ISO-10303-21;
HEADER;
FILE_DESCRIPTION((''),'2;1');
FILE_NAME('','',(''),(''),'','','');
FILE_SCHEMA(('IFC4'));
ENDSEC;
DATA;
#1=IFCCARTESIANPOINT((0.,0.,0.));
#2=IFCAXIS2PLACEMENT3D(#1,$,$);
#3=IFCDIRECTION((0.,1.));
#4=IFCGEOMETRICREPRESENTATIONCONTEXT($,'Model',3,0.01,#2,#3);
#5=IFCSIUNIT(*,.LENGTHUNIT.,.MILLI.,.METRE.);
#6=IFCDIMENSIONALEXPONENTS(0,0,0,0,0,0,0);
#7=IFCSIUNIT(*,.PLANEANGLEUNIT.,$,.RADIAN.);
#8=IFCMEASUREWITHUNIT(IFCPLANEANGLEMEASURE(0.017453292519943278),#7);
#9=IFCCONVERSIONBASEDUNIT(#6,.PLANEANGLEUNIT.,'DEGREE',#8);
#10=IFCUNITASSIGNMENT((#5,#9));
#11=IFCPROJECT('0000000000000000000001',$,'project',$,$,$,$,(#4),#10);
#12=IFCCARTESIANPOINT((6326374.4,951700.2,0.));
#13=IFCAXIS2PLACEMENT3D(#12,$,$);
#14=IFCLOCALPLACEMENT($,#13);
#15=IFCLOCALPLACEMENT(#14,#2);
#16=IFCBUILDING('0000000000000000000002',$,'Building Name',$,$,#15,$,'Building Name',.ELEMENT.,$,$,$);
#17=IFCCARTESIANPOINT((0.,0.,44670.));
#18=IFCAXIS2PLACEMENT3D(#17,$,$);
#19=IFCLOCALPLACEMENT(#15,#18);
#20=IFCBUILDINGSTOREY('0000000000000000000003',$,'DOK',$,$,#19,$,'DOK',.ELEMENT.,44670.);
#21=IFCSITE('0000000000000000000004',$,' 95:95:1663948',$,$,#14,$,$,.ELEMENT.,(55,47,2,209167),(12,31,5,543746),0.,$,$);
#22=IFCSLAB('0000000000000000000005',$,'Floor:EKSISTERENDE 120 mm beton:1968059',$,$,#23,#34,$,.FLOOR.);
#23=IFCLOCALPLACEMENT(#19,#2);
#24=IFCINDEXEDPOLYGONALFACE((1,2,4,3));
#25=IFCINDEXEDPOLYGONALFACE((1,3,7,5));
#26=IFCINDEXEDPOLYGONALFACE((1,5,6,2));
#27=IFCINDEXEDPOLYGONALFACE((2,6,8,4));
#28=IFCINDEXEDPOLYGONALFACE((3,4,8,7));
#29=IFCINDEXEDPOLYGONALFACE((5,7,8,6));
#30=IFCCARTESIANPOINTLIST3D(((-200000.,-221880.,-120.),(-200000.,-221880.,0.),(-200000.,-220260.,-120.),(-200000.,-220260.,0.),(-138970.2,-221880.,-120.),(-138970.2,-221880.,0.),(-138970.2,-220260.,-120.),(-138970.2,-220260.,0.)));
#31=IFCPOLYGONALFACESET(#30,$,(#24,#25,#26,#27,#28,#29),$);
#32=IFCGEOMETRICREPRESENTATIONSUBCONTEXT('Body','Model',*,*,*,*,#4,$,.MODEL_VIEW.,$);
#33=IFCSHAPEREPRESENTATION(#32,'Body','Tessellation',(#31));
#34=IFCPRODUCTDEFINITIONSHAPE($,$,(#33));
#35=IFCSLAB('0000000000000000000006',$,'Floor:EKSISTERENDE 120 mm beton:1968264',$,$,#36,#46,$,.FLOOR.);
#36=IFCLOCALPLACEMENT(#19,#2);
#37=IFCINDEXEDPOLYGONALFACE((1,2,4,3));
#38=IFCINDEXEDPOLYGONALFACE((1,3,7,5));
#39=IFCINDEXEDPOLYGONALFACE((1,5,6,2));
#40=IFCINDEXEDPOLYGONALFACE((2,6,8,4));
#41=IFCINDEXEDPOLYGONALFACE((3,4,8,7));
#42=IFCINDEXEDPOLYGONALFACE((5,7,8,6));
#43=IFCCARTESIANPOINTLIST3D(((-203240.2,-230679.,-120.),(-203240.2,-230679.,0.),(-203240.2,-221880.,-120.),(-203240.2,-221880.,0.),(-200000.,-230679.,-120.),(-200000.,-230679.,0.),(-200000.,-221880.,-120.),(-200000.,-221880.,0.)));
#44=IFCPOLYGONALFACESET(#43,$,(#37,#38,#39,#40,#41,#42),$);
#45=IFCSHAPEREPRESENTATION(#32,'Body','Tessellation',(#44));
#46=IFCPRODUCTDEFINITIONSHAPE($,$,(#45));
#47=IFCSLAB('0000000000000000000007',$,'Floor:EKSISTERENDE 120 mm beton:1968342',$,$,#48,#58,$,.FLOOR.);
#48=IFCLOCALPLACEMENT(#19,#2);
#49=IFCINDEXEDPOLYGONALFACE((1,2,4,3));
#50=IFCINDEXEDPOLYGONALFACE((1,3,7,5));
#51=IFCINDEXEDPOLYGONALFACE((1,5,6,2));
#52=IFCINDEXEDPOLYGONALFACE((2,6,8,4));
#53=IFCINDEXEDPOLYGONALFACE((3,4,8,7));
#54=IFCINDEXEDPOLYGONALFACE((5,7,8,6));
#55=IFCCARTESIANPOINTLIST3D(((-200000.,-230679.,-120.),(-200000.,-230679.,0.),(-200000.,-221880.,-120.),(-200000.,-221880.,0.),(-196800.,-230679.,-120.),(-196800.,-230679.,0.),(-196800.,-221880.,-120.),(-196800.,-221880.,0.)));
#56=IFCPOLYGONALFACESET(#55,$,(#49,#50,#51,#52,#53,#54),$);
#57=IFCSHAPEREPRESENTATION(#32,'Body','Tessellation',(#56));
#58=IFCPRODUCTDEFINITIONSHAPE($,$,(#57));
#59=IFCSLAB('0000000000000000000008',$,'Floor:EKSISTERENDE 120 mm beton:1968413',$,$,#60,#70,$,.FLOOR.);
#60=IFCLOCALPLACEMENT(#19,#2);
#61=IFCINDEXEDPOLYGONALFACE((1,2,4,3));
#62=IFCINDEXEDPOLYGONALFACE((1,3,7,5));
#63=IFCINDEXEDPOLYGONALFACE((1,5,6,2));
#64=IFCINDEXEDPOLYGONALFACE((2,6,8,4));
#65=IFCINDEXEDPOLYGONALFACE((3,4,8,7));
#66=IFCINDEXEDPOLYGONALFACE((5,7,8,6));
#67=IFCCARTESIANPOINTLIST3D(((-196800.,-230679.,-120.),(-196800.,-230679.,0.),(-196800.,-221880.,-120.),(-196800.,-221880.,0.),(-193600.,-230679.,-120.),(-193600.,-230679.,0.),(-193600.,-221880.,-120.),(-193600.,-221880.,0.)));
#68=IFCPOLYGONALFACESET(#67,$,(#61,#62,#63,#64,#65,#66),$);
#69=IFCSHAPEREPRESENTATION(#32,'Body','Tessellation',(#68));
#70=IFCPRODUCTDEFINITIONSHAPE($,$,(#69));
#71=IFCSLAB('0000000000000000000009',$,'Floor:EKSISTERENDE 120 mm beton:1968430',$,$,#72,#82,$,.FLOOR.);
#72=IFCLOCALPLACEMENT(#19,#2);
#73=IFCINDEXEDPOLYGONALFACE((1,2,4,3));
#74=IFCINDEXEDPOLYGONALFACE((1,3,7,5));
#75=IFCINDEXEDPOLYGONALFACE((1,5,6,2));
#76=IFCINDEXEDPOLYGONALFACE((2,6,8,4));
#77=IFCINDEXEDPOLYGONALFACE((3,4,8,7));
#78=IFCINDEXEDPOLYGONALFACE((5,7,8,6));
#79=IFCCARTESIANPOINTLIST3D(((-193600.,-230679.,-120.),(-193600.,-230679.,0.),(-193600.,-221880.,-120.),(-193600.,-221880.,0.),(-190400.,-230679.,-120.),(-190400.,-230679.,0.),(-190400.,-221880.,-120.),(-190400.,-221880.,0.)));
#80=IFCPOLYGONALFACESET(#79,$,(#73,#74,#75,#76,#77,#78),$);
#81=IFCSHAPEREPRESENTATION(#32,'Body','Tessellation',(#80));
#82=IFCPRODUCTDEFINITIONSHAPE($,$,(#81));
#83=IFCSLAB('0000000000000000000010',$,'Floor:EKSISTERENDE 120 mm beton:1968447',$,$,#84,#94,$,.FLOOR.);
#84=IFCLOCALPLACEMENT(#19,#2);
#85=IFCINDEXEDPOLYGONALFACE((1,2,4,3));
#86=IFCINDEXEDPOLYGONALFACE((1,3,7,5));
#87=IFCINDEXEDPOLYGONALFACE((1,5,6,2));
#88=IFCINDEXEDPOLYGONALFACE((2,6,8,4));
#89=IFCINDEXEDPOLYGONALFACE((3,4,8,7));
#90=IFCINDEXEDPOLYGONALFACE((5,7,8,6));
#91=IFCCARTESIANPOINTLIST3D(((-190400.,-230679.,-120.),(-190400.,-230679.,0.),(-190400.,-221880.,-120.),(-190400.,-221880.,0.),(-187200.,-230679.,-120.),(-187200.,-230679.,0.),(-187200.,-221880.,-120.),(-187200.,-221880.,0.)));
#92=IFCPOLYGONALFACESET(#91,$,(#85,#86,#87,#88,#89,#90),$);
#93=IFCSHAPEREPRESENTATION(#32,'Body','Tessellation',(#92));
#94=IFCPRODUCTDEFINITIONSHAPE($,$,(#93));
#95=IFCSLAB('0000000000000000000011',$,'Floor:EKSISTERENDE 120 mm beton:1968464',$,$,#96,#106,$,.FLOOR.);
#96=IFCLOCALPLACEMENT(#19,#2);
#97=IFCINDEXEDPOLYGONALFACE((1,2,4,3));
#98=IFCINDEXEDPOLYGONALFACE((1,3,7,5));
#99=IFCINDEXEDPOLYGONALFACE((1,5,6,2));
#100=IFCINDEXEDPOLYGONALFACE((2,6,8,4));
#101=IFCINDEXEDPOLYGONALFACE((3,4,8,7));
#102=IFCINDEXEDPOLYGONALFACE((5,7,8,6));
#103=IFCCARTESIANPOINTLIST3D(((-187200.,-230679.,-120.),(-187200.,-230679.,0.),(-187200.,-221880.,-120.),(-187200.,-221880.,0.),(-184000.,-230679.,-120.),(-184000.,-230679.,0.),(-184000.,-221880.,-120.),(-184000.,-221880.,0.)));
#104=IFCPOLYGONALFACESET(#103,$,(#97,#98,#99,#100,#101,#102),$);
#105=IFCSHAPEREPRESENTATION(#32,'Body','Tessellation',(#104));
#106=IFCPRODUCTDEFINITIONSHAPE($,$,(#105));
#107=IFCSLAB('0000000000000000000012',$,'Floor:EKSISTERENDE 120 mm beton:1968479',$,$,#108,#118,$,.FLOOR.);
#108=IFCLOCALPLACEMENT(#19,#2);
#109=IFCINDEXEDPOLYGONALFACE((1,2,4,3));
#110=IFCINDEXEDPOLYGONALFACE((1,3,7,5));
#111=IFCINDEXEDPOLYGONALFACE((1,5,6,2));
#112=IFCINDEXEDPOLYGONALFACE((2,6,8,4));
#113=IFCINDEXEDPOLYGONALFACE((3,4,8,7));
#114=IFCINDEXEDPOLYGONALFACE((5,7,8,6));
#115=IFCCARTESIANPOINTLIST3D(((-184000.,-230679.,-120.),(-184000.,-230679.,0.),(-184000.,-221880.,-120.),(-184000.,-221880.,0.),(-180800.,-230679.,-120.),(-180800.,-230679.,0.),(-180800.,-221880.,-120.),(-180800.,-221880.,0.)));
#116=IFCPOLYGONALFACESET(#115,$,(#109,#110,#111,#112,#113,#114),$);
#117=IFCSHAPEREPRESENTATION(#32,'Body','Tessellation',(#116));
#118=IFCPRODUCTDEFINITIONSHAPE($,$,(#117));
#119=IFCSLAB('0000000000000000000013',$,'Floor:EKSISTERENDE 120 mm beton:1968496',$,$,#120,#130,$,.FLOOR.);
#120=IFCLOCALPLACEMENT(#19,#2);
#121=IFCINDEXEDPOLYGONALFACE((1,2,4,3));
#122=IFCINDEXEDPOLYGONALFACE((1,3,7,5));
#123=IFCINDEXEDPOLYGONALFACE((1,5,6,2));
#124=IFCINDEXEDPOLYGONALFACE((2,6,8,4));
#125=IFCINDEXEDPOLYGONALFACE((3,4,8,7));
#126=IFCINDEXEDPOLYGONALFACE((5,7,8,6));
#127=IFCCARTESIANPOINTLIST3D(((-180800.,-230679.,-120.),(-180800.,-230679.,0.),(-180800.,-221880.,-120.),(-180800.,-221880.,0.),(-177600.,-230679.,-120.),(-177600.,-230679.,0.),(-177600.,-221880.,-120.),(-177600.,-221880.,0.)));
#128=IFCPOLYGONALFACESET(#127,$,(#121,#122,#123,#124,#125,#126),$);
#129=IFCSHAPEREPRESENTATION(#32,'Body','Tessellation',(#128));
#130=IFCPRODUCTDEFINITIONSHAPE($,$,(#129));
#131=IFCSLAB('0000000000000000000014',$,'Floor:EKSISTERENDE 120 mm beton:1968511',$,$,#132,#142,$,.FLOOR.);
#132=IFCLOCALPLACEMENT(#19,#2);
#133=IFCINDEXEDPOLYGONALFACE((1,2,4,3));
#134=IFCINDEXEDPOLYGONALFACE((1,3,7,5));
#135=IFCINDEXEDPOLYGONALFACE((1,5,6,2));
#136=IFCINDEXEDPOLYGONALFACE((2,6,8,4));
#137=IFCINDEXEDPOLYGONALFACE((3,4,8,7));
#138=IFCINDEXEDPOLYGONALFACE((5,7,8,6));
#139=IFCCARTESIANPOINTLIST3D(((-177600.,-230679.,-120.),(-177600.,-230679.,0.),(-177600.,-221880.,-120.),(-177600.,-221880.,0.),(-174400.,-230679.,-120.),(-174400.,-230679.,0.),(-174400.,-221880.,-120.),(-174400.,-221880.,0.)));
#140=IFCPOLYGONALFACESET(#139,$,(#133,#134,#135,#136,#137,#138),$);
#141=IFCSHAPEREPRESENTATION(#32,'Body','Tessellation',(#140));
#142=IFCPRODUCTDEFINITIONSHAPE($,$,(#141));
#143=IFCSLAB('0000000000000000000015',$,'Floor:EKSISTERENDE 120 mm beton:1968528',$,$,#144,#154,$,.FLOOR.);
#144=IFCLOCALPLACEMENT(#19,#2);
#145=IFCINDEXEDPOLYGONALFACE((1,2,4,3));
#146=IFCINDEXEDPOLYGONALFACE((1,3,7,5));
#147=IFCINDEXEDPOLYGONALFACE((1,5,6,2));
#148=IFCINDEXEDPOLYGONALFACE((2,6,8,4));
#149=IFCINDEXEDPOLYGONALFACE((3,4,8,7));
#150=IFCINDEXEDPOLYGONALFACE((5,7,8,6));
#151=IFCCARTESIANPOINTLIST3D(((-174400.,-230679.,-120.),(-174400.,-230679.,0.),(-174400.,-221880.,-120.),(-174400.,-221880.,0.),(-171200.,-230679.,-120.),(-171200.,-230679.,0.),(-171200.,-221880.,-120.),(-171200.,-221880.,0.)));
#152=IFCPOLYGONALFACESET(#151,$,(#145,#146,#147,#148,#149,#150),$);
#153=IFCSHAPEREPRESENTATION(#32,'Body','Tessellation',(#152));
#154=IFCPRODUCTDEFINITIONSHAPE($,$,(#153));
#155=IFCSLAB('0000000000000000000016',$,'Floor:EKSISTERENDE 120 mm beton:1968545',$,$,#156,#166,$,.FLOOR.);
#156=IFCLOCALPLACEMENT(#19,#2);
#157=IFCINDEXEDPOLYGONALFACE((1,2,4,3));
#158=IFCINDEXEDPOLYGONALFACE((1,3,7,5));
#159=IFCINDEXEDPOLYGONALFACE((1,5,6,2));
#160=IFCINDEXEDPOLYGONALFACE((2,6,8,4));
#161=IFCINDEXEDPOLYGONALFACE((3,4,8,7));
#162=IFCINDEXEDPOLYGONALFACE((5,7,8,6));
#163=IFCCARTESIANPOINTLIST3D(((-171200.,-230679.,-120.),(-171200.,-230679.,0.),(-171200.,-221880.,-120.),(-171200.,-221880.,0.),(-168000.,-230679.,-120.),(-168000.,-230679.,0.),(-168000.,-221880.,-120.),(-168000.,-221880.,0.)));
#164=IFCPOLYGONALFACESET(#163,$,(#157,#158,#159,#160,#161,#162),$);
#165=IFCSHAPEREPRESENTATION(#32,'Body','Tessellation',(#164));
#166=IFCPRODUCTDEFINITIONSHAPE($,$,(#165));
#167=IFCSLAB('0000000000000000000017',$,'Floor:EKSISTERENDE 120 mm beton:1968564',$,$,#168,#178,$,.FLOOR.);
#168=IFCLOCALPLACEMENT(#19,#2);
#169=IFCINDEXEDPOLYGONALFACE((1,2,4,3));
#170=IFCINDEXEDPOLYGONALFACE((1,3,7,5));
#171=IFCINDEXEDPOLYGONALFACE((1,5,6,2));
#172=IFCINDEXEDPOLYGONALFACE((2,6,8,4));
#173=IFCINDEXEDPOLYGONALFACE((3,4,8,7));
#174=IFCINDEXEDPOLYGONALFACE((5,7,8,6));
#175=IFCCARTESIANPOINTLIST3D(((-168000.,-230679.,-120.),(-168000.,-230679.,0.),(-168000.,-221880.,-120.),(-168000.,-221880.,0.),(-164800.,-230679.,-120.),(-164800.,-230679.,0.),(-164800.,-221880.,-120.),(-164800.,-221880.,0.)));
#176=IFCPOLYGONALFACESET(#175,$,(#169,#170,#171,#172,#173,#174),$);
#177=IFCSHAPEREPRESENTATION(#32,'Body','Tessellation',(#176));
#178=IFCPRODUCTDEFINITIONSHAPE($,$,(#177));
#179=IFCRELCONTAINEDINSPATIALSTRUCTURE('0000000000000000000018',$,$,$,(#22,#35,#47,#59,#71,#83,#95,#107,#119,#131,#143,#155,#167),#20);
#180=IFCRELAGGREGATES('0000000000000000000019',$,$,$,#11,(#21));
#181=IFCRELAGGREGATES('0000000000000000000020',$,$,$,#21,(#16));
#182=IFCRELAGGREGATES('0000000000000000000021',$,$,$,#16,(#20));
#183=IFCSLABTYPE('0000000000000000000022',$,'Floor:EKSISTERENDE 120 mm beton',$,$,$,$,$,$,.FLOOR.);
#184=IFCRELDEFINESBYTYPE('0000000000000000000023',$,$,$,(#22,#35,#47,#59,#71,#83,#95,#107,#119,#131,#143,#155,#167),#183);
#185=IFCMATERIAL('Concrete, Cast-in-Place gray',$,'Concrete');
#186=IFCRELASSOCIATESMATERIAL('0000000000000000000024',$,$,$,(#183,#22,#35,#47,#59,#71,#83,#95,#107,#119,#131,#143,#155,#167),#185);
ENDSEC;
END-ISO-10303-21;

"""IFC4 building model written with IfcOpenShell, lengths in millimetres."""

from ifc_helpers import new_model, entity, si_unit, converted_unit, direction, frame, origin, place, context, subcontext, project, spatial, indexed_curve, outline, extrude, material, type_object, element, save


model = new_model("IFC4")

# Units and contexts
model_context = context("Model", 3, precision=0.01, world=origin(), true_north=direction((0.0, 1.0)))
body_context = subcontext(model_context, "Body", "Model", "MODEL_VIEW")
ifc_project = project(units=[si_unit("LENGTHUNIT", "METRE", prefix="MILLI"), converted_unit("PLANEANGLEUNIT", "DEGREE", entity("IfcPlaneAngleMeasure", 0.017453292519943278), si_unit("PLANEANGLEUNIT", "RADIAN"), dimensions=[0, 0, 0, 0, 0, 0, 0])], contexts=[model_context])

# Site, building, storey
site_placement = place(None, frame((6326374.4, 951700.2, 0.0)))
site = spatial("IfcSite", under=ifc_project, at=site_placement, Name=" 95:95:1663948", CompositionType="ELEMENT", RefLatitude=(55, 47, 2, 209167), RefLongitude=(12, 31, 5, 543746), RefElevation=0.0)
building_placement = place(site_placement, origin())
building = spatial("IfcBuilding", under=site, at=building_placement, Name="Building Name", LongName="Building Name", CompositionType="ELEMENT")
storey_placement = place(building_placement, frame((0.0, 0.0, 44670.0)))
storey = spatial("IfcBuildingStorey", under=building, at=storey_placement, Name="DOK", LongName="DOK", CompositionType="ELEMENT", Elevation=44670.0)

# Slabs
ifc_material = material(Name="Concrete, Cast-in-Place gray", Category="Concrete")
slab_type_1 = type_object("IfcSlabType", Name="Floor:EKSISTERENDE 120 mm beton", PredefinedType="FLOOR", material=ifc_material)
slab_1_placement = place(storey_placement, origin())
element("IfcSlab", 1, at=slab_1_placement, inside=storey, type_object=slab_type_1, material=ifc_material, Name="Floor:EKSISTERENDE 120 mm beton:1968059", PredefinedType="FLOOR", context=body_context, shape_type="SweptSolid", body=[
    extrude(outline(indexed_curve([(-810.0, -30514.9), (810.0, -30514.9), (810.0, 30514.9), (-810.0, 30514.9), (-810.0, -30514.9)], self_intersect=False)), frame((-169485.1, -221070.0, 0.0), z_axis=(0.0, 0.0, -1.0), x_axis=(0.0, 1.0, 0.0)), (0.0, 0.0, 1.0), 120.0),
])
slab_2_placement = place(storey_placement, origin())
element("IfcSlab", 2, at=slab_2_placement, inside=storey, type_object=slab_type_1, material=ifc_material, Name="Floor:EKSISTERENDE 120 mm beton:1968264", PredefinedType="FLOOR", context=body_context, shape_type="SweptSolid", body=[
    extrude(outline(indexed_curve([(-4399.5, -1620.1), (4399.5, -1620.1), (4399.5, 1620.1), (-4399.5, 1620.1), (-4399.5, -1620.1)], self_intersect=False)), frame((-201620.1, -226279.5, 0.0), z_axis=(0.0, 0.0, -1.0), x_axis=(0.0, 1.0, 0.0)), (0.0, 0.0, 1.0), 120.0),
])
slab_3_placement = place(storey_placement, origin())
element("IfcSlab", 3, at=slab_3_placement, inside=storey, type_object=slab_type_1, material=ifc_material, Name="Floor:EKSISTERENDE 120 mm beton:1968342", PredefinedType="FLOOR", context=body_context, shape_type="SweptSolid", body=[
    extrude(outline(indexed_curve([(-4399.5, -1600.0), (4399.5, -1600.0), (4399.5, 1600.0), (-4399.5, 1600.0), (-4399.5, -1600.0)], self_intersect=False)), frame((-198400.0, -226279.5, 0.0), z_axis=(0.0, 0.0, -1.0), x_axis=(0.0, 1.0, 0.0)), (0.0, 0.0, 1.0), 120.0),
])
slab_4_placement = place(storey_placement, origin())
element("IfcSlab", 4, at=slab_4_placement, inside=storey, type_object=slab_type_1, material=ifc_material, Name="Floor:EKSISTERENDE 120 mm beton:1968413", PredefinedType="FLOOR", context=body_context, shape_type="SweptSolid", body=[
    extrude(outline(indexed_curve([(-4399.5, -1600.0), (4399.5, -1600.0), (4399.5, 1600.0), (-4399.5, 1600.0), (-4399.5, -1600.0)], self_intersect=False)), frame((-195200.0, -226279.5, 0.0), z_axis=(0.0, 0.0, -1.0), x_axis=(0.0, 1.0, 0.0)), (0.0, 0.0, 1.0), 120.0),
])
slab_5_placement = place(storey_placement, origin())
element("IfcSlab", 5, at=slab_5_placement, inside=storey, type_object=slab_type_1, material=ifc_material, Name="Floor:EKSISTERENDE 120 mm beton:1968430", PredefinedType="FLOOR", context=body_context, shape_type="SweptSolid", body=[
    extrude(outline(indexed_curve([(-4399.5, -1600.0), (4399.5, -1600.0), (4399.5, 1600.0), (-4399.5, 1600.0), (-4399.5, -1600.0)], self_intersect=False)), frame((-192000.0, -226279.5, 0.0), z_axis=(0.0, 0.0, -1.0), x_axis=(0.0, 1.0, 0.0)), (0.0, 0.0, 1.0), 120.0),
])
slab_6_placement = place(storey_placement, origin())
element("IfcSlab", 6, at=slab_6_placement, inside=storey, type_object=slab_type_1, material=ifc_material, Name="Floor:EKSISTERENDE 120 mm beton:1968447", PredefinedType="FLOOR", context=body_context, shape_type="SweptSolid", body=[
    extrude(outline(indexed_curve([(-4399.5, -1600.0), (4399.5, -1600.0), (4399.5, 1600.0), (-4399.5, 1600.0), (-4399.5, -1600.0)], self_intersect=False)), frame((-188800.0, -226279.5, 0.0), z_axis=(0.0, 0.0, -1.0), x_axis=(0.0, 1.0, 0.0)), (0.0, 0.0, 1.0), 120.0),
])
slab_7_placement = place(storey_placement, origin())
element("IfcSlab", 7, at=slab_7_placement, inside=storey, type_object=slab_type_1, material=ifc_material, Name="Floor:EKSISTERENDE 120 mm beton:1968464", PredefinedType="FLOOR", context=body_context, shape_type="SweptSolid", body=[
    extrude(outline(indexed_curve([(-4399.5, -1600.0), (4399.5, -1600.0), (4399.5, 1600.0), (-4399.5, 1600.0), (-4399.5, -1600.0)], self_intersect=False)), frame((-185600.0, -226279.5, 0.0), z_axis=(0.0, 0.0, -1.0), x_axis=(0.0, 1.0, 0.0)), (0.0, 0.0, 1.0), 120.0),
])
slab_8_placement = place(storey_placement, origin())
element("IfcSlab", 8, at=slab_8_placement, inside=storey, type_object=slab_type_1, material=ifc_material, Name="Floor:EKSISTERENDE 120 mm beton:1968479", PredefinedType="FLOOR", context=body_context, shape_type="SweptSolid", body=[
    extrude(outline(indexed_curve([(-4399.5, -1600.0), (4399.5, -1600.0), (4399.5, 1600.0), (-4399.5, 1600.0), (-4399.5, -1600.0)], self_intersect=False)), frame((-182400.0, -226279.5, 0.0), z_axis=(0.0, 0.0, -1.0), x_axis=(0.0, 1.0, 0.0)), (0.0, 0.0, 1.0), 120.0),
])
slab_9_placement = place(storey_placement, origin())
element("IfcSlab", 9, at=slab_9_placement, inside=storey, type_object=slab_type_1, material=ifc_material, Name="Floor:EKSISTERENDE 120 mm beton:1968496", PredefinedType="FLOOR", context=body_context, shape_type="SweptSolid", body=[
    extrude(outline(indexed_curve([(-4399.5, -1600.0), (4399.5, -1600.0), (4399.5, 1600.0), (-4399.5, 1600.0), (-4399.5, -1600.0)], self_intersect=False)), frame((-179200.0, -226279.5, 0.0), z_axis=(0.0, 0.0, -1.0), x_axis=(0.0, 1.0, 0.0)), (0.0, 0.0, 1.0), 120.0),
])
slab_10_placement = place(storey_placement, origin())
element("IfcSlab", 10, at=slab_10_placement, inside=storey, type_object=slab_type_1, material=ifc_material, Name="Floor:EKSISTERENDE 120 mm beton:1968511", PredefinedType="FLOOR", context=body_context, shape_type="SweptSolid", body=[
    extrude(outline(indexed_curve([(-4399.5, -1600.0), (4399.5, -1600.0), (4399.5, 1600.0), (-4399.5, 1600.0), (-4399.5, -1600.0)], self_intersect=False)), frame((-176000.0, -226279.5, 0.0), z_axis=(0.0, 0.0, -1.0), x_axis=(0.0, 1.0, 0.0)), (0.0, 0.0, 1.0), 120.0),
])
slab_11_placement = place(storey_placement, origin())
element("IfcSlab", 11, at=slab_11_placement, inside=storey, type_object=slab_type_1, material=ifc_material, Name="Floor:EKSISTERENDE 120 mm beton:1968528", PredefinedType="FLOOR", context=body_context, shape_type="SweptSolid", body=[
    extrude(outline(indexed_curve([(-4399.5, -1600.0), (4399.5, -1600.0), (4399.5, 1600.0), (-4399.5, 1600.0), (-4399.5, -1600.0)], self_intersect=False)), frame((-172800.0, -226279.5, 0.0), z_axis=(0.0, 0.0, -1.0), x_axis=(0.0, 1.0, 0.0)), (0.0, 0.0, 1.0), 120.0),
])
slab_12_placement = place(storey_placement, origin())
element("IfcSlab", 12, at=slab_12_placement, inside=storey, type_object=slab_type_1, material=ifc_material, Name="Floor:EKSISTERENDE 120 mm beton:1968545", PredefinedType="FLOOR", context=body_context, shape_type="SweptSolid", body=[
    extrude(outline(indexed_curve([(-4399.5, -1600.0), (4399.5, -1600.0), (4399.5, 1600.0), (-4399.5, 1600.0), (-4399.5, -1600.0)], self_intersect=False)), frame((-169600.0, -226279.5, 0.0), z_axis=(0.0, 0.0, -1.0), x_axis=(0.0, 1.0, 0.0)), (0.0, 0.0, 1.0), 120.0),
])
slab_13_placement = place(storey_placement, origin())
element("IfcSlab", 13, at=slab_13_placement, inside=storey, type_object=slab_type_1, material=ifc_material, Name="Floor:EKSISTERENDE 120 mm beton:1968564", PredefinedType="FLOOR", context=body_context, shape_type="SweptSolid", body=[
    extrude(outline(indexed_curve([(-4399.5, -1600.0), (4399.5, -1600.0), (4399.5, 1600.0), (-4399.5, 1600.0), (-4399.5, -1600.0)], self_intersect=False)), frame((-166400.0, -226279.5, 0.0), z_axis=(0.0, 0.0, -1.0), x_axis=(0.0, 1.0, 0.0)), (0.0, 0.0, 1.0), 120.0),
])

save(model, "model.ifc")
